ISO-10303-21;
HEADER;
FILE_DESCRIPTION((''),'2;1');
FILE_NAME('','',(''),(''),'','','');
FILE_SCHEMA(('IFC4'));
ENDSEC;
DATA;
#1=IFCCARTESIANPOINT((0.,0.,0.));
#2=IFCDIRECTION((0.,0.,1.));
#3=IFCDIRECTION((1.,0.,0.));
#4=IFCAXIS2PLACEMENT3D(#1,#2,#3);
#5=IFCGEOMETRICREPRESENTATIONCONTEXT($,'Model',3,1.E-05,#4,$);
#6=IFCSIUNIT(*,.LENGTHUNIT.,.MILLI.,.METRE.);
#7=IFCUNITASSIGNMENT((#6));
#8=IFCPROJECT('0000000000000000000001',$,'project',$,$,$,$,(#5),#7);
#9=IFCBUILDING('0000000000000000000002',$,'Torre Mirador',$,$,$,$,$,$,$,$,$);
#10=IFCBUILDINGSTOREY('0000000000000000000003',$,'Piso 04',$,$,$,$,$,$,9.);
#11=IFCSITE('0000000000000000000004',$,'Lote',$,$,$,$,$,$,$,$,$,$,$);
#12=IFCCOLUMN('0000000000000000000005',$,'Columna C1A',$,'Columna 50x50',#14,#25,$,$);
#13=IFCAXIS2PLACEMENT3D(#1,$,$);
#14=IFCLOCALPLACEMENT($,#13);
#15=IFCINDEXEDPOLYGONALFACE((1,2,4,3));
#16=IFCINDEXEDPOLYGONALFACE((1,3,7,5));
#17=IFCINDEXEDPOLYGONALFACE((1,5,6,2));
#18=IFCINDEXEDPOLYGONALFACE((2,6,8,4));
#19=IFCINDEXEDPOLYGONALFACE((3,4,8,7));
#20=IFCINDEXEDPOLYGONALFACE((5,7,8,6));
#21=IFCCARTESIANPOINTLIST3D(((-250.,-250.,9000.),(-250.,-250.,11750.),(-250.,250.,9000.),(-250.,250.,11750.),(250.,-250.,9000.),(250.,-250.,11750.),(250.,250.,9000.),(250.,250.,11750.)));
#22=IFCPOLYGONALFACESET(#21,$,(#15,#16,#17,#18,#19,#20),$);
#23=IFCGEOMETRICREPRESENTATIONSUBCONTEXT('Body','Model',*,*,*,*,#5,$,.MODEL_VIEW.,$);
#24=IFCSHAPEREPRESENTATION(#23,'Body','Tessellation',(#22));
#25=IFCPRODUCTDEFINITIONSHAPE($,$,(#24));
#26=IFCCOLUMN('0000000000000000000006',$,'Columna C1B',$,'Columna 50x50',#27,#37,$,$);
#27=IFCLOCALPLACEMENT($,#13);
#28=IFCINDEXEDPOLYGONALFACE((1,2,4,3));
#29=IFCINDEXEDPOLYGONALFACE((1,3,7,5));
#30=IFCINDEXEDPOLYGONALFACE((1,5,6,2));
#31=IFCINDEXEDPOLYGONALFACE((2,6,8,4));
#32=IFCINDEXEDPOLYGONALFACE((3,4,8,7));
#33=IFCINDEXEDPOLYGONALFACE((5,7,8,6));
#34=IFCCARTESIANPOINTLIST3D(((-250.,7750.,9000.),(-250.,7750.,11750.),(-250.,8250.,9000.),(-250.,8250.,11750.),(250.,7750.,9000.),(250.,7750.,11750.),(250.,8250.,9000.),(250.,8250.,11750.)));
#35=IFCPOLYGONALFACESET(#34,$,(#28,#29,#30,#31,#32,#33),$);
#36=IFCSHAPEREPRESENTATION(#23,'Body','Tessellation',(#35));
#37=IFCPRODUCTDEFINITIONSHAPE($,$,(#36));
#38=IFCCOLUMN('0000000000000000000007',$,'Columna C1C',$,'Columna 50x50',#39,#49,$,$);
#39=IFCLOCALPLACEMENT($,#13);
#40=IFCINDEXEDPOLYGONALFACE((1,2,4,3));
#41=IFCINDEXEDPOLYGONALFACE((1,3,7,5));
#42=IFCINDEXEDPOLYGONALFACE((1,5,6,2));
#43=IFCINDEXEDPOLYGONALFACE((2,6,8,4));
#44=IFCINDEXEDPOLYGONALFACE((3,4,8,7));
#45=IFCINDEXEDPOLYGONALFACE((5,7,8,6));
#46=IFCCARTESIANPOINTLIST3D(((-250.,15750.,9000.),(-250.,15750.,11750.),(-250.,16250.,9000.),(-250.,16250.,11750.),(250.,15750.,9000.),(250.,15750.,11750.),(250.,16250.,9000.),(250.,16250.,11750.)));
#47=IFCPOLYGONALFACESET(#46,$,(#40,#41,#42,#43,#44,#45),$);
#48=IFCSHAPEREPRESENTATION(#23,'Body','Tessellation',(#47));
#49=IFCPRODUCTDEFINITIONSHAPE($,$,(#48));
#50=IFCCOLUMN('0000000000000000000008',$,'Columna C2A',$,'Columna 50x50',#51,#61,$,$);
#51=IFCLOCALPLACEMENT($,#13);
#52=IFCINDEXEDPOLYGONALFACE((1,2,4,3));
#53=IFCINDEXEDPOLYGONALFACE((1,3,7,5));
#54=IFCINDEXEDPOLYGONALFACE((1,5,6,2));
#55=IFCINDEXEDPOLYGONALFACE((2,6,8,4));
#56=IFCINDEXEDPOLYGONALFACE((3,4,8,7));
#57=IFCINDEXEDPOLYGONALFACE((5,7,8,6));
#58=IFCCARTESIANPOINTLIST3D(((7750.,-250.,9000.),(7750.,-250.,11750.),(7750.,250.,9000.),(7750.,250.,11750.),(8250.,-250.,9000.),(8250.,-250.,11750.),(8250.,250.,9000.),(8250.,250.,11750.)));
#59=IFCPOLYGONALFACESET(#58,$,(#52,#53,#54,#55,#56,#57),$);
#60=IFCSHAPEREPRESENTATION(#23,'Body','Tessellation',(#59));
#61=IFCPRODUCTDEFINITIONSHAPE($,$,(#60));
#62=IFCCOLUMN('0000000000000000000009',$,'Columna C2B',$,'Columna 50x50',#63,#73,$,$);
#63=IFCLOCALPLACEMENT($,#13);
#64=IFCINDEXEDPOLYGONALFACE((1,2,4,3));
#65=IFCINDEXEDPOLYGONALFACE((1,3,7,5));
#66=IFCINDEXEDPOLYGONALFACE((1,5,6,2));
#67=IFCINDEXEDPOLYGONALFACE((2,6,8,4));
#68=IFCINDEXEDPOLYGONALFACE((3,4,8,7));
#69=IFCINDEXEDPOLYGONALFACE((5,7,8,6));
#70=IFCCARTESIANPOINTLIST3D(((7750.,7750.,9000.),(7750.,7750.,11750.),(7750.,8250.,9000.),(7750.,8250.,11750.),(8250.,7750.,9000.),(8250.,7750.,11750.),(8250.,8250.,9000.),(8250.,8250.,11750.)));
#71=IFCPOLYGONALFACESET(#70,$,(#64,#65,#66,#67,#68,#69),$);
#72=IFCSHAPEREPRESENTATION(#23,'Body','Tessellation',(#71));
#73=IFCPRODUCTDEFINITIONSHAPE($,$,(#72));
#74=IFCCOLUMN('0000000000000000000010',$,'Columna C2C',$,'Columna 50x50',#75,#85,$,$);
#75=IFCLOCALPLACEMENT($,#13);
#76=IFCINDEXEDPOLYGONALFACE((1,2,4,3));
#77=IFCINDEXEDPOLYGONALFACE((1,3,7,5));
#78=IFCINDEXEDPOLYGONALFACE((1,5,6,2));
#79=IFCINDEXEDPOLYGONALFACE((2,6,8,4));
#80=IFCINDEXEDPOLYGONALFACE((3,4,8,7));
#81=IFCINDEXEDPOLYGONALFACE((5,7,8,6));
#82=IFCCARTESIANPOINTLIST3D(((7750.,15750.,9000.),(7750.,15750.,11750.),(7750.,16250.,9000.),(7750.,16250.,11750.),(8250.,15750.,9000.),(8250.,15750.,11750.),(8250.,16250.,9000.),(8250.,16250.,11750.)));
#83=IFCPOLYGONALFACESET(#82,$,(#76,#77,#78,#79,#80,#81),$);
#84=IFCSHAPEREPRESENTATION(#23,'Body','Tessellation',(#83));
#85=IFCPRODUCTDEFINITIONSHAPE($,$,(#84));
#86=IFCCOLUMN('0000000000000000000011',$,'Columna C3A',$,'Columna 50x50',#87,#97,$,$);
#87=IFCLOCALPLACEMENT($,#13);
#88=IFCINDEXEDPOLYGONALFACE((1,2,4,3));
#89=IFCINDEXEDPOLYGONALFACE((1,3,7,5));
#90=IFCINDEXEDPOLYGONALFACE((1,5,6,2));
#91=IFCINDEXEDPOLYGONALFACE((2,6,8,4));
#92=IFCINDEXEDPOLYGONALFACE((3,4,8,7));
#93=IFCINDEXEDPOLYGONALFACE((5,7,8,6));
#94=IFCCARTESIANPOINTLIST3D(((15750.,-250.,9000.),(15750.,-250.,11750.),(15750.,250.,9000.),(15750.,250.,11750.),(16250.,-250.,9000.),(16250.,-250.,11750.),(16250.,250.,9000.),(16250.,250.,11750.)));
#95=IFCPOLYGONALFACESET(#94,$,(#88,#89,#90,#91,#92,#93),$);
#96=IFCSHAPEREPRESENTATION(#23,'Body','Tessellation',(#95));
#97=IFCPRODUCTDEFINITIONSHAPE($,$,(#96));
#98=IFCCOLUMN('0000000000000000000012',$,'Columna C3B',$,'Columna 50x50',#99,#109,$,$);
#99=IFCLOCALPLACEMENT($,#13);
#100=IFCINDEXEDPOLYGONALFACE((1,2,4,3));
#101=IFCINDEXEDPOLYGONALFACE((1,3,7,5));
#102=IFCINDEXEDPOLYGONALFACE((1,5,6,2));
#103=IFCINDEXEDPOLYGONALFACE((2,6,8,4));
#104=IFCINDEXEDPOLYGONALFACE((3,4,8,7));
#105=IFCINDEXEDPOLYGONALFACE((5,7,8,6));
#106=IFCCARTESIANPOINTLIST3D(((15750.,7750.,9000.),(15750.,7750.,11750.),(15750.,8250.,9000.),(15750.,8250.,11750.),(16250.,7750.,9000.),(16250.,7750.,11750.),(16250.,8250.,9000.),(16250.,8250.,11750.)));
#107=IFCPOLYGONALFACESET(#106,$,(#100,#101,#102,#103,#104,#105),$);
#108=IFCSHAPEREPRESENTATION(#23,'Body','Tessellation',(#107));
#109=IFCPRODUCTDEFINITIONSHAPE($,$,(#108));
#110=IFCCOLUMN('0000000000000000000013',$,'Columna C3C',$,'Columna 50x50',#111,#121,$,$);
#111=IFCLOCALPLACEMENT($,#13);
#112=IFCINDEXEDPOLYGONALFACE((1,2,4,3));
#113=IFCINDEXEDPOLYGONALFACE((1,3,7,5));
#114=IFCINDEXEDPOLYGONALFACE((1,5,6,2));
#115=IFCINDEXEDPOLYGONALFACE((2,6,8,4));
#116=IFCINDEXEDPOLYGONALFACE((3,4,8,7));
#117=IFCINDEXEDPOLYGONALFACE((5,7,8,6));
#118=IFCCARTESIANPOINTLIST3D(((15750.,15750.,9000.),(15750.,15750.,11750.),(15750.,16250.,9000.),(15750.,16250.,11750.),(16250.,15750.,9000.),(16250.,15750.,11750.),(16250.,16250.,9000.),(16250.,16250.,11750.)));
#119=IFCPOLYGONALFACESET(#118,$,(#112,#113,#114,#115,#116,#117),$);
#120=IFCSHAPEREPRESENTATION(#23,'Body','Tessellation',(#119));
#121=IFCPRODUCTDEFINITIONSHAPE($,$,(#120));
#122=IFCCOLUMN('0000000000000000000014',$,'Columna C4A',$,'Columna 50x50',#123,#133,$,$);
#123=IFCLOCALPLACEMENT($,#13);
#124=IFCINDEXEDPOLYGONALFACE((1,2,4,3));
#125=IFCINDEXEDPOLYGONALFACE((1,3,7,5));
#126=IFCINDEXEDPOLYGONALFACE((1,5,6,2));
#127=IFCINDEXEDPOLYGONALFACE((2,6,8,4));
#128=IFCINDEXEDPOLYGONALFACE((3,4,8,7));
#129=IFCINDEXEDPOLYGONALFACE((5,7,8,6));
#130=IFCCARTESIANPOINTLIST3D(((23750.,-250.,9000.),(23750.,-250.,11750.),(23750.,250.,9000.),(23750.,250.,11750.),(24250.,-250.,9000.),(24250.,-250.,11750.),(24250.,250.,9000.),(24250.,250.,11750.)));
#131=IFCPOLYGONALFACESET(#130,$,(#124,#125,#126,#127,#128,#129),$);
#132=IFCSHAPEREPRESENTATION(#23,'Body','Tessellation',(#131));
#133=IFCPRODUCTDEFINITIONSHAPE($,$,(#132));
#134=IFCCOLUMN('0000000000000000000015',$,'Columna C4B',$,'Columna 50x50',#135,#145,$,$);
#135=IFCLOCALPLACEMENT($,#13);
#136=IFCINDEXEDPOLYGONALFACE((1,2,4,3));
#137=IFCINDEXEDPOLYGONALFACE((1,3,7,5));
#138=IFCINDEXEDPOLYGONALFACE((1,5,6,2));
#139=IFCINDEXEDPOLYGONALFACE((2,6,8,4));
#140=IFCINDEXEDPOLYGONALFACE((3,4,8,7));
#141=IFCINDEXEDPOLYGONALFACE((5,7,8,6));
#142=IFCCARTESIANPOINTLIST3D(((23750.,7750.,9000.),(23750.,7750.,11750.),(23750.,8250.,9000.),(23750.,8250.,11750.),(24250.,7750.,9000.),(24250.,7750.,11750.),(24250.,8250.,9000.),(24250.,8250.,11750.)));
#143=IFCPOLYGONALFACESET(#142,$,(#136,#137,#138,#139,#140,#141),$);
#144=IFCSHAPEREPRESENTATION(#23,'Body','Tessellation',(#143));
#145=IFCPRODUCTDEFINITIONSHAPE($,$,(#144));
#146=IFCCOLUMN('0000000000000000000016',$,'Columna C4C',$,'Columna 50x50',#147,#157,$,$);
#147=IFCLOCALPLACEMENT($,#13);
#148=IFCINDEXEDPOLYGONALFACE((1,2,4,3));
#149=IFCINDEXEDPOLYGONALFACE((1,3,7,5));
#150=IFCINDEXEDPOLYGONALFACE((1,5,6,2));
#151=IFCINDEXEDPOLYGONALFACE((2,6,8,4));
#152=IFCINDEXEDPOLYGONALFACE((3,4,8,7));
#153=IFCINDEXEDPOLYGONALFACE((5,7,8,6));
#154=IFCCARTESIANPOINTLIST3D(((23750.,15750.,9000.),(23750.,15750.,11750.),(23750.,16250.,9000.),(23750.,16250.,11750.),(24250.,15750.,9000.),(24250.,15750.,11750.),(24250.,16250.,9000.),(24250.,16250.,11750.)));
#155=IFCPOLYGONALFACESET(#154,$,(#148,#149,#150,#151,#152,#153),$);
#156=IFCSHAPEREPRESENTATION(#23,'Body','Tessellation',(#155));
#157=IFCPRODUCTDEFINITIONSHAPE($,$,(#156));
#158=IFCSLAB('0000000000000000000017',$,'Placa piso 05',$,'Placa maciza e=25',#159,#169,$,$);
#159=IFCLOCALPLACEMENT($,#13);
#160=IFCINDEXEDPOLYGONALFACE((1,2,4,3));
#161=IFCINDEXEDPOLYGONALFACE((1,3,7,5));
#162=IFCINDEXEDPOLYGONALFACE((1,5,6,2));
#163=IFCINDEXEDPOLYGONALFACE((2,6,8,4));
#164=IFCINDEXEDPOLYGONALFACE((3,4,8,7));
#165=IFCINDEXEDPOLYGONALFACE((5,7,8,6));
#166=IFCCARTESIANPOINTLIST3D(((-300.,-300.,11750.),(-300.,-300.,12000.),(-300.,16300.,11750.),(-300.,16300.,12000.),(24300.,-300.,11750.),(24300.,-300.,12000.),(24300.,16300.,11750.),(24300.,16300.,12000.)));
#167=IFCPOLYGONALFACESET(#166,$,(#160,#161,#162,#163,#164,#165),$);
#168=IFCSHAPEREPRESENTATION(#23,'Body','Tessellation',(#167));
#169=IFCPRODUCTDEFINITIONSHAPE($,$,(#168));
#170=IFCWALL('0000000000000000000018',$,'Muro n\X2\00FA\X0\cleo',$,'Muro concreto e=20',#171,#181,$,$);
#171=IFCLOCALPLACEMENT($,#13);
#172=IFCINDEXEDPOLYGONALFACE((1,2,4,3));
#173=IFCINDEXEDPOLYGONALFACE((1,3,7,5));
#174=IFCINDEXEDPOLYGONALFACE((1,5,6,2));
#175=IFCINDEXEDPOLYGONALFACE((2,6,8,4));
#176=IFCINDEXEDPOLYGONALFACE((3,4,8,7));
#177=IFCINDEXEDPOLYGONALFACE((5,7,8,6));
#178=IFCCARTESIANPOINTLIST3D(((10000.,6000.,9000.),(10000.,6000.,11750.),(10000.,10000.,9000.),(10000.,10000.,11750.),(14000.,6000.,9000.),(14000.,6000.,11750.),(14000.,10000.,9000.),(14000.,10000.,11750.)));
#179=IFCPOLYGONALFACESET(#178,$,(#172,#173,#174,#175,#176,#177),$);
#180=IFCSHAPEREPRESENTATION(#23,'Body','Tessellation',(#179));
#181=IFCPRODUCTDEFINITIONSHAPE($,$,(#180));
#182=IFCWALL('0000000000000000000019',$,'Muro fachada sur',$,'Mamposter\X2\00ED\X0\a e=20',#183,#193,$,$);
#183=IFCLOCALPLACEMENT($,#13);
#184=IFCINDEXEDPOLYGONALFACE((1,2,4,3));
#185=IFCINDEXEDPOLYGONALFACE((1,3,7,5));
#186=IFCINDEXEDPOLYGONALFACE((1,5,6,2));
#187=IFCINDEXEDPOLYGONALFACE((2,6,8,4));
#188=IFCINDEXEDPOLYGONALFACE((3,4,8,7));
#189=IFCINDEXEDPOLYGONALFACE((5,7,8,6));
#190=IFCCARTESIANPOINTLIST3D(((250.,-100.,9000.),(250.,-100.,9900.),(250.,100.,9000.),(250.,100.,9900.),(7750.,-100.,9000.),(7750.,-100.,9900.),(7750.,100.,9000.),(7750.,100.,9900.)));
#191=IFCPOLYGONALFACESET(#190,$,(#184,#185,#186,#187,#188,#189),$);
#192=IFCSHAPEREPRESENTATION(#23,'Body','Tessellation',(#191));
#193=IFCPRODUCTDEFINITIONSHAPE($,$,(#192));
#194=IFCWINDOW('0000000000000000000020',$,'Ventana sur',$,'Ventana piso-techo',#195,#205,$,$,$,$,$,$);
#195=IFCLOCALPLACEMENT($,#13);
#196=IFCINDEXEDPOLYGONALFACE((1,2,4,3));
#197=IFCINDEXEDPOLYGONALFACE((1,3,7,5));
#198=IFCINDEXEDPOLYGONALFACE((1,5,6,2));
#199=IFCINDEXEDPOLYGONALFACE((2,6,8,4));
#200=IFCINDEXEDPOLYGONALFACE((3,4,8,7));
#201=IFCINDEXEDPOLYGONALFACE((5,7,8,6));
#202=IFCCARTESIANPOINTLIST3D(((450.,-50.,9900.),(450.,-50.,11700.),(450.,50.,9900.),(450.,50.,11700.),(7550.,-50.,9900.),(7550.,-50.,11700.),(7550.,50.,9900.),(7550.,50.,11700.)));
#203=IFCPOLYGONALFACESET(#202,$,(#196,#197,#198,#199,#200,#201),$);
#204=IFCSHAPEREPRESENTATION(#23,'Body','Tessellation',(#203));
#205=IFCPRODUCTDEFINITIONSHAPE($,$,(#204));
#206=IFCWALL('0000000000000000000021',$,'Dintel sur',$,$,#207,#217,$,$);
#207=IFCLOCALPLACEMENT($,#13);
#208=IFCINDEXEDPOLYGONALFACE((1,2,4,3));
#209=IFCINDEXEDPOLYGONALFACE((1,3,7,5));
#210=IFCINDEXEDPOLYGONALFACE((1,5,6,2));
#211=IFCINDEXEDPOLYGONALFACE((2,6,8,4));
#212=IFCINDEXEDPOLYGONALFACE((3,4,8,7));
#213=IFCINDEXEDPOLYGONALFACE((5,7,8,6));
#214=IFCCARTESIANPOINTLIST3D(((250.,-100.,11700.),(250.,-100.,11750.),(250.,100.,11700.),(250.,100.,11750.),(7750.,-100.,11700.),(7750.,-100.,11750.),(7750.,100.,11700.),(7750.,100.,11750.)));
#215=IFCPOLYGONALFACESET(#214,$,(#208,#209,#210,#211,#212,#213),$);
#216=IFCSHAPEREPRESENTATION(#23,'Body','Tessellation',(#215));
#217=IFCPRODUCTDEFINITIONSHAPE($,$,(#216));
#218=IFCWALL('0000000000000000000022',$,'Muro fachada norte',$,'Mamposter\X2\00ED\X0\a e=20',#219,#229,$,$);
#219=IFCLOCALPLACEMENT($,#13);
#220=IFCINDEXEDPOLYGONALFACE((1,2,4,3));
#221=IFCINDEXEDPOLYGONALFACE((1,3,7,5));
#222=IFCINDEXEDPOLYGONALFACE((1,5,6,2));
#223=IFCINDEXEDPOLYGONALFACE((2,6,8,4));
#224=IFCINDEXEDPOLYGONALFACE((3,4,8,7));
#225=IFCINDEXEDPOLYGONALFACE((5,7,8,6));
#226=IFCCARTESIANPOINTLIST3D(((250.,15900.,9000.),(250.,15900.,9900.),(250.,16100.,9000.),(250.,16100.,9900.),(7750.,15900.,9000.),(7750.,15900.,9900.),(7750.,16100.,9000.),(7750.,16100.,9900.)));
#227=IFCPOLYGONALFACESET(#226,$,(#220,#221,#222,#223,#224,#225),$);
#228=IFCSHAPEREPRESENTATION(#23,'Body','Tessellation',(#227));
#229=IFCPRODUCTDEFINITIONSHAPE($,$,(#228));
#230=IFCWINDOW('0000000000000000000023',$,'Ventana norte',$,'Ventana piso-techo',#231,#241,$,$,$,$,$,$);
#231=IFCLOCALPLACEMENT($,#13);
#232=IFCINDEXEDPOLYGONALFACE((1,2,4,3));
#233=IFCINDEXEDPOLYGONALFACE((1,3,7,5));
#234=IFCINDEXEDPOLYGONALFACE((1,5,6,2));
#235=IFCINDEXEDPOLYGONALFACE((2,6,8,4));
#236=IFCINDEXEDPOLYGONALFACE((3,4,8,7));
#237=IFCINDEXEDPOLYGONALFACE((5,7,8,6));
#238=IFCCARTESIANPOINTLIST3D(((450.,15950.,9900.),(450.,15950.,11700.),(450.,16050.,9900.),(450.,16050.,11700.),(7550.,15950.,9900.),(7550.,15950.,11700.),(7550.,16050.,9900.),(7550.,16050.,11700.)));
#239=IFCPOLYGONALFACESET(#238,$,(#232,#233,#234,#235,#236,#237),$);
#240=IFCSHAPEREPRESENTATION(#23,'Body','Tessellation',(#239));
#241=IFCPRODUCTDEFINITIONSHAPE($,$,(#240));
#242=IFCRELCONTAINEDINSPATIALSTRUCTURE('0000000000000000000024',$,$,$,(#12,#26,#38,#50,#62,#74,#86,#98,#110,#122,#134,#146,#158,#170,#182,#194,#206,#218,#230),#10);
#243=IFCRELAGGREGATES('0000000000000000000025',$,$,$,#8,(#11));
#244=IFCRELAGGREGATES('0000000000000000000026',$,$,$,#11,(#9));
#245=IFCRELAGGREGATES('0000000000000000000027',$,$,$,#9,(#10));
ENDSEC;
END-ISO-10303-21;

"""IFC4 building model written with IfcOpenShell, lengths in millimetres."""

from ifc_helpers import new_model, si_unit, frame, origin_with_axes, place, context, subcontext, project, spatial, indexed_curve, outline, extrude, element, save


model = new_model("IFC4")

# Units and contexts
model_context = context("Model", 3, precision=1e-05, world=origin_with_axes())
body_context = subcontext(model_context, "Body", "Model", "MODEL_VIEW")
ifc_project = project(units=[si_unit("LENGTHUNIT", "METRE", prefix="MILLI")], contexts=[model_context])

# Site, building, storey
site = spatial("IfcSite", under=ifc_project, Name="Lote")
building = spatial("IfcBuilding", under=site, Name="Torre Mirador")
storey = spatial("IfcBuildingStorey", under=building, Name="Piso 04", Elevation=9.0)

# Columns
for number, where, z_axis, x_axis, name in (
    (1, (-250.0, -250.0, 9000.0), (0.0, 0.0, 1.0), (1.0, 0.0, 0.0), "Columna C1A"),
    (2, (-250.0, 7750.0, 9000.0), (0.0, 0.0, 1.0), (1.0, 0.0, 0.0), "Columna C1B"),
    (3, (-250.0, 15750.0, 9000.0), (0.0, 0.0, 1.0), (1.0, 0.0, 0.0), "Columna C1C"),
    (4, (7750.0, -250.0, 9000.0), (0.0, 0.0, 1.0), (1.0, 0.0, 0.0), "Columna C2A"),
    (5, (7750.0, 7750.0, 9000.0), (0.0, 0.0, 1.0), (1.0, 0.0, 0.0), "Columna C2B"),
    (6, (7750.0, 15750.0, 9000.0), (0.0, 0.0, 1.0), (1.0, 0.0, 0.0), "Columna C2C"),
    (7, (15750.0, -250.0, 9000.0), (0.0, 0.0, 1.0), (1.0, 0.0, 0.0), "Columna C3A"),
    (8, (15750.0, 7750.0, 9000.0), (0.0, 0.0, 1.0), (1.0, 0.0, 0.0), "Columna C3B"),
    (9, (15750.0, 15750.0, 9000.0), (0.0, 0.0, 1.0), (1.0, 0.0, 0.0), "Columna C3C"),
    (10, (23750.0, -250.0, 9000.0), (0.0, 0.0, 1.0), (1.0, 0.0, 0.0), "Columna C4A"),
    (11, (23750.0, 7750.0, 9000.0), (0.0, 0.0, 1.0), (1.0, 0.0, 0.0), "Columna C4B"),
    (12, (23750.0, 15750.0, 9000.0), (0.0, 0.0, 1.0), (1.0, 0.0, 0.0), "Columna C4C"),
):
    element("IfcColumn", number, at=place(None, frame(where, z_axis=z_axis, x_axis=x_axis)), inside=storey, Name=name, ObjectType="Columna 50x50", context=body_context, shape_type="SweptSolid", body=[
        extrude(outline(indexed_curve([(0.0, 0.0), (0.0, 500.0), (500.0, 500.0), (500.0, 0.0), (0.0, 0.0)], self_intersect=False)), origin_with_axes(), (0.0, 0.0, 1.0), 2750.0),
    ])

# Slab
slab_placement = place(None, frame((-300.0, -300.0, 11750.0), z_axis=(0.0, 0.0, 1.0), x_axis=(1.0, 0.0, 0.0)))
element("IfcSlab", 13, at=slab_placement, inside=storey, Name="Placa piso 05", ObjectType="Placa maciza e=25", context=body_context, shape_type="SweptSolid", body=[
    extrude(outline(indexed_curve([(0.0, 0.0), (0.0, 16600.0), (24600.0, 16600.0), (24600.0, 0.0), (0.0, 0.0)], self_intersect=False)), origin_with_axes(), (0.0, 0.0, 1.0), 250.0),
])

# Walls
wall_1_placement = place(None, frame((10000.0, 6000.0, 9000.0), z_axis=(0.0, 0.0, 1.0), x_axis=(1.0, 0.0, 0.0)))
element("IfcWall", 14, at=wall_1_placement, inside=storey, Name="Muro núcleo", ObjectType="Muro concreto e=20", context=body_context, shape_type="SweptSolid", body=[
    extrude(outline(indexed_curve([(0.0, 0.0), (0.0, 4000.0), (4000.0, 4000.0), (4000.0, 0.0), (0.0, 0.0)], self_intersect=False)), origin_with_axes(), (0.0, 0.0, 1.0), 2750.0),
])
wall_2_placement = place(None, frame((250.0, -100.0, 9000.0), z_axis=(0.0, 0.0, 1.0), x_axis=(1.0, 0.0, 0.0)))
element("IfcWall", 15, at=wall_2_placement, inside=storey, Name="Muro fachada sur", ObjectType="Mampostería e=20", context=body_context, shape_type="SweptSolid", body=[
    extrude(outline(indexed_curve([(0.0, 0.0), (0.0, 200.0), (7500.0, 200.0), (7500.0, 0.0), (0.0, 0.0)], self_intersect=False)), origin_with_axes(), (0.0, 0.0, 1.0), 900.0),
])

# Window
window_1_placement = place(None, frame((450.0, -50.0, 9900.0), z_axis=(0.0, 0.0, 1.0), x_axis=(1.0, 0.0, 0.0)))
element("IfcWindow", 16, at=window_1_placement, inside=storey, Name="Ventana sur", ObjectType="Ventana piso-techo", context=body_context, shape_type="SweptSolid", body=[
    extrude(outline(indexed_curve([(0.0, 0.0), (0.0, 100.0), (7100.0, 100.0), (7100.0, 0.0), (0.0, 0.0)], self_intersect=False)), origin_with_axes(), (0.0, 0.0, 1.0), 1800.0),
])

# Walls
wall_3_placement = place(None, frame((250.0, -100.0, 11700.0), z_axis=(0.0, 0.0, 1.0), x_axis=(1.0, 0.0, 0.0)))
element("IfcWall", 17, at=wall_3_placement, inside=storey, Name="Dintel sur", context=body_context, shape_type="SweptSolid", body=[
    extrude(outline(indexed_curve([(0.0, 0.0), (0.0, 200.0), (7500.0, 200.0), (7500.0, 0.0), (0.0, 0.0)], self_intersect=False)), origin_with_axes(), (0.0, 0.0, 1.0), 50.0),
])
wall_4_placement = place(None, frame((250.0, 15900.0, 9000.0), z_axis=(0.0, 0.0, 1.0), x_axis=(1.0, 0.0, 0.0)))
element("IfcWall", 18, at=wall_4_placement, inside=storey, Name="Muro fachada norte", ObjectType="Mampostería e=20", context=body_context, shape_type="SweptSolid", body=[
    extrude(outline(indexed_curve([(0.0, 0.0), (0.0, 200.0), (7500.0, 200.0), (7500.0, 0.0), (0.0, 0.0)], self_intersect=False)), origin_with_axes(), (0.0, 0.0, 1.0), 900.0),
])

# Window
window_2_placement = place(None, frame((450.0, 15950.0, 9900.0), z_axis=(0.0, 0.0, 1.0), x_axis=(1.0, 0.0, 0.0)))
element("IfcWindow", 19, at=window_2_placement, inside=storey, Name="Ventana norte", ObjectType="Ventana piso-techo", context=body_context, shape_type="SweptSolid", body=[
    extrude(outline(indexed_curve([(0.0, 0.0), (0.0, 100.0), (7100.0, 100.0), (7100.0, 0.0), (0.0, 0.0)], self_intersect=False)), origin_with_axes(), (0.0, 0.0, 1.0), 1800.0),
])

save(model, "model.ifc")
